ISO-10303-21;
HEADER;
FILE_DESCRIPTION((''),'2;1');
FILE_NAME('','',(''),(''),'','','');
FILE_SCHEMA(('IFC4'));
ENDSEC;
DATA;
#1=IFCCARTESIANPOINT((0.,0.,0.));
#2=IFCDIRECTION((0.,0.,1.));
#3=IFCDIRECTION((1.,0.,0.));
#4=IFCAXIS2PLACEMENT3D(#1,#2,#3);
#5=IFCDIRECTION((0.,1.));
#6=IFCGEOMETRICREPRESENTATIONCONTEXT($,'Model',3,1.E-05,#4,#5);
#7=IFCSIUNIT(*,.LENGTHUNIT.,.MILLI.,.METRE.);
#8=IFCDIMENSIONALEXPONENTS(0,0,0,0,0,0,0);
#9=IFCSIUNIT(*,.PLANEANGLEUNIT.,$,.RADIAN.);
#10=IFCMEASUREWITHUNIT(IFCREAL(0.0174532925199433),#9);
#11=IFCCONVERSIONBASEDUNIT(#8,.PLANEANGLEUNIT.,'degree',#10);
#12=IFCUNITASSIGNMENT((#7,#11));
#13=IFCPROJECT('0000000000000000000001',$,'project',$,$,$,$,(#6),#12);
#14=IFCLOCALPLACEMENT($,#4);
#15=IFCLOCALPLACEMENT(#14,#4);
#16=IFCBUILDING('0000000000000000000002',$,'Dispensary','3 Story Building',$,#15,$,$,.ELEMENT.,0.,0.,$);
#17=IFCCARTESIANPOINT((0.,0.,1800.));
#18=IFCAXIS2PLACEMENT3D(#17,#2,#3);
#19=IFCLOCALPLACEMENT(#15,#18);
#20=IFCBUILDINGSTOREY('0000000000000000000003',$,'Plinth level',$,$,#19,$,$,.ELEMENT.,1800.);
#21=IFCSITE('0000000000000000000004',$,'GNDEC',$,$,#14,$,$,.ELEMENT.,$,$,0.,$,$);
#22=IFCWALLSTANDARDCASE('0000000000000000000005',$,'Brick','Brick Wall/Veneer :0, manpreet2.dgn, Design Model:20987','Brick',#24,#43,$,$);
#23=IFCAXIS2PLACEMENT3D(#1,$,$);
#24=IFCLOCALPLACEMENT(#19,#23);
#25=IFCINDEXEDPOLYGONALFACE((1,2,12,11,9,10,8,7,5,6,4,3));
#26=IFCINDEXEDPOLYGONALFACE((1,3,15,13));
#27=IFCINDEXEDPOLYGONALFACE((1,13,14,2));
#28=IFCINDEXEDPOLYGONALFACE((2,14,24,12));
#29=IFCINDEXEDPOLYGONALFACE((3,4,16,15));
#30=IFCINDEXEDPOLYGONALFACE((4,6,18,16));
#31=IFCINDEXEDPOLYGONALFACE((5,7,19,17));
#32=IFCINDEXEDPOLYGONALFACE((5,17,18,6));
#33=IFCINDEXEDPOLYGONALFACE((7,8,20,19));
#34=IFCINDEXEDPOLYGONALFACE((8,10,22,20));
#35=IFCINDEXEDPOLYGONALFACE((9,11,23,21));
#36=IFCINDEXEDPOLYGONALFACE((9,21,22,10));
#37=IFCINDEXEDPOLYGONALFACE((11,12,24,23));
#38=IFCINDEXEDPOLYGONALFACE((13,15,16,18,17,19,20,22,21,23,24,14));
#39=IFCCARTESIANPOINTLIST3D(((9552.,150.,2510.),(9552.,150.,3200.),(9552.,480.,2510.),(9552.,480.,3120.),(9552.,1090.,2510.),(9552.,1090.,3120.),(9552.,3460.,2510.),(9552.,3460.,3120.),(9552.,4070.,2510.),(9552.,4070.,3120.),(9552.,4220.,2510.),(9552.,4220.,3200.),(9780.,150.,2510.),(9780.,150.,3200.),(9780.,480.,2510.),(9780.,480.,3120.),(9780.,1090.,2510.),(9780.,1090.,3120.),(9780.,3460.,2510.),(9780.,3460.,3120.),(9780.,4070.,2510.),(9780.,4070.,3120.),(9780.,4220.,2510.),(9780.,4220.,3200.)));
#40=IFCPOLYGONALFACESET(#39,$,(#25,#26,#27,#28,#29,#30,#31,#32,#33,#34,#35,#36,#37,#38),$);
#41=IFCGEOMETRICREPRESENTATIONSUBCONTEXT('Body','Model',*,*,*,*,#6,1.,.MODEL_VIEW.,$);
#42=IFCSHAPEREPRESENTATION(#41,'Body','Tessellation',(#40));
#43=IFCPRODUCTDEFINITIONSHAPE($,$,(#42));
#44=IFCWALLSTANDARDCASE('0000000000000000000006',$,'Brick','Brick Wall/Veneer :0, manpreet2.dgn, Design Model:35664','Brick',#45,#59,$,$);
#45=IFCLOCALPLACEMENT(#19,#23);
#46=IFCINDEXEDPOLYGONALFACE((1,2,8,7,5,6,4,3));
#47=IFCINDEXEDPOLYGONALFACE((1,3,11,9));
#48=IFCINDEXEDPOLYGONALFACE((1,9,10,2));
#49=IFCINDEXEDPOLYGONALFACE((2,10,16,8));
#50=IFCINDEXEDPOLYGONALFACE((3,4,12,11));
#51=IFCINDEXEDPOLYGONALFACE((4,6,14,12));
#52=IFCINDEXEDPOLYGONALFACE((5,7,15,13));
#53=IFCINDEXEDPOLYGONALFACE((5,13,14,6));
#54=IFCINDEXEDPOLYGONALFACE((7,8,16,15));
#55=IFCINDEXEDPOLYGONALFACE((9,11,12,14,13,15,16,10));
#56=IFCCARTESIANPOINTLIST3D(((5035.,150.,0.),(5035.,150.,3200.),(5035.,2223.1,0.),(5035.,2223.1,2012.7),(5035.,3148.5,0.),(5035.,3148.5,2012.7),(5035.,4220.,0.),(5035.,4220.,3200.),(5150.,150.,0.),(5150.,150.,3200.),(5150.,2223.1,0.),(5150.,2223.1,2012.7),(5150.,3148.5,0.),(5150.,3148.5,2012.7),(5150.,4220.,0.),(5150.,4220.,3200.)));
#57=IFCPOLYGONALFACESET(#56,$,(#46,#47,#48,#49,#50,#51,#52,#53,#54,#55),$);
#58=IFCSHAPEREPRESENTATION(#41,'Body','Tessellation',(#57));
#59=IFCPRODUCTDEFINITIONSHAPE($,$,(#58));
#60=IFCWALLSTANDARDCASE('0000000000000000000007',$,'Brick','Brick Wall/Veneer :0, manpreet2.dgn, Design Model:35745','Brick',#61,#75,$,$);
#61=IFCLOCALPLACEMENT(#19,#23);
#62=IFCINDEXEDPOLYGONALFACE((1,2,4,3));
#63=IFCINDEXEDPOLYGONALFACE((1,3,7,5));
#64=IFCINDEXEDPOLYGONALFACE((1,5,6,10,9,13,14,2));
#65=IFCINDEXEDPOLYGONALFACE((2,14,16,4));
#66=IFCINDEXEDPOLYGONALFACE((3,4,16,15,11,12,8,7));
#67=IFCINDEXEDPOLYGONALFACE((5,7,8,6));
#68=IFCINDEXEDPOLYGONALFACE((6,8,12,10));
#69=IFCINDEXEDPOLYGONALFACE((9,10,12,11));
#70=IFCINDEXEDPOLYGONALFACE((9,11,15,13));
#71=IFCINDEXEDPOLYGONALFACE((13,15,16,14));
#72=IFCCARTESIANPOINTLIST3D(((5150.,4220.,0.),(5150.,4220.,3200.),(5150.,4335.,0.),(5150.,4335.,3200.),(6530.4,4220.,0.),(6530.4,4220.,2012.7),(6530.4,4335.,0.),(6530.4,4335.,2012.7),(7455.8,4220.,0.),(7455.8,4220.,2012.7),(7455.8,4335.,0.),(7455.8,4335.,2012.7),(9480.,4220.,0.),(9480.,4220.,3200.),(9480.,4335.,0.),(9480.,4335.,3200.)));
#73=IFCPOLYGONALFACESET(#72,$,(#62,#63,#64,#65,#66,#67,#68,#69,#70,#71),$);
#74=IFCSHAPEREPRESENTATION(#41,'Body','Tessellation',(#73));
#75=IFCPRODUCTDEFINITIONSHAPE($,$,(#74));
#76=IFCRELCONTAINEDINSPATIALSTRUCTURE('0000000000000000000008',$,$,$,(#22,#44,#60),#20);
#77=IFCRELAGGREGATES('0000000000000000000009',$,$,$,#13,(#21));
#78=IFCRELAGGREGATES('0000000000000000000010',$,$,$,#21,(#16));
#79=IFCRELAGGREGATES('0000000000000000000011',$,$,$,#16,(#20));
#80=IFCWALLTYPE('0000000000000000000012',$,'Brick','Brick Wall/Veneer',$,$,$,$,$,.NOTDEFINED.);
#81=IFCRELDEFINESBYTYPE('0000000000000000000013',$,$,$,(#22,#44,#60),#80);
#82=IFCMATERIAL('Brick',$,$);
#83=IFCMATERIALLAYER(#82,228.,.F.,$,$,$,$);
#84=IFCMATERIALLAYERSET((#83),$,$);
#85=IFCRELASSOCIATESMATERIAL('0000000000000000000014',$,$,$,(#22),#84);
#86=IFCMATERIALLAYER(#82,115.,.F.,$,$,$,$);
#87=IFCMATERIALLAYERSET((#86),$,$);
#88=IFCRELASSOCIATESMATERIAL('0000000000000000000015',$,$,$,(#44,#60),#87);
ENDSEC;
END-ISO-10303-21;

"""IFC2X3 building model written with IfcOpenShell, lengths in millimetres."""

from ifc_helpers import new_model, entity, si_unit, converted_unit, direction, frame, frame_2d, origin_with_axes, place, context, subcontext, project, spatial, rectangle, extrude, material, layer, layer_set, layer_usage, type_object, element, save


model = new_model("IFC2X3")

# Units and contexts
model_context = context("Model", 3, precision=1e-05, world=origin_with_axes(), true_north=direction((0.0, 1.0)))
body_context = subcontext(model_context, "Body", "Model", "MODEL_VIEW", scale=1.0)
ifc_project = project(units=[si_unit("LENGTHUNIT", "METRE", prefix="MILLI"), converted_unit("PLANEANGLEUNIT", "degree", entity("IfcReal", 0.0174532925199433), si_unit("PLANEANGLEUNIT", "RADIAN"), dimensions=[0, 0, 0, 0, 0, 0, 0])], contexts=[model_context])

# Site, building, storey
site_placement = place(None, origin_with_axes())
site = spatial("IfcSite", under=ifc_project, at=site_placement, Name="GNDEC", CompositionType="ELEMENT", RefElevation=0.0)
building_placement = place(site_placement, origin_with_axes())
building = spatial("IfcBuilding", under=site, at=building_placement, Name="Dispensary", Description="3 Story Building", CompositionType="ELEMENT", ElevationOfRefHeight=0.0, ElevationOfTerrain=0.0)
storey_placement = place(building_placement, frame((0.0, 0.0, 1800.0), z_axis=(0.0, 0.0, 1.0), x_axis=(1.0, 0.0, 0.0)))
storey = spatial("IfcBuildingStorey", under=building, at=storey_placement, Name="Plinth level", CompositionType="ELEMENT", Elevation=1800.0)

# Wall, openings
ifc_material_1 = material(Name="Brick")
ifc_layer_1 = layer(ifc_material_1, 228.0, ventilated=False)
ifc_layer_set_1 = layer_set([ifc_layer_1])
ifc_layer_usage_1 = layer_usage(ifc_layer_set_1, "AXIS2", "POSITIVE", 0.0)
wall_type = type_object("IfcWallType", Name="Brick", Description="Brick Wall/Veneer", PredefinedType="NOTDEFINED")
wall_1_placement = place(storey_placement, frame((9780.0, 4220.0, 2510.0), z_axis=(0.0, 0.0, 1.0), x_axis=(0.0, -1.0, 0.0)))
wall_1 = element("IfcWallStandardCase", 1, at=wall_1_placement, inside=storey, type_object=wall_type, material=ifc_layer_usage_1, Name="Brick", Description="Brick Wall/Veneer :0, manpreet2.dgn, Design Model:20987", ObjectType="Brick", context=body_context, shape_type="SweptSolid", body=[
    extrude(rectangle(XDim=4070.0, YDim=228.0, at=frame_2d((2035.0, -114.0), x_axis=(-1.0, 0.0))), origin_with_axes(), (0.0, 0.0, 1.0), 690.0),
])
opening_1_placement = place(wall_1_placement, frame((150.0, -228.0, -760.0), z_axis=(0.0, 0.0, 1.0), x_axis=(1.0, 0.0, 0.0)))
element("IfcOpeningElement", 2, at=opening_1_placement, cuts=wall_1, ObjectType="Opening", context=body_context, shape_type="SweptSolid", body=[
    extrude(rectangle(XDim=1370.0, YDim=610.0, at=frame_2d((-305.0, 685.0), x_axis=(0.0, -1.0))), frame((0.0, 0.0, 0.0), z_axis=(0.0, 1.0, 0.0), x_axis=(-1.0, 0.0, 0.0)), (0.0, 0.0, 1.0), 228.0),
])
opening_2_placement = place(wall_1_placement, frame((3130.0, -228.0, -760.0), z_axis=(0.0, 0.0, 1.0), x_axis=(1.0, 0.0, 0.0)))
element("IfcOpeningElement", 3, at=opening_2_placement, cuts=wall_1, ObjectType="Opening", context=body_context, shape_type="SweptSolid", body=[
    extrude(rectangle(XDim=1370.0, YDim=610.0, at=frame_2d((-305.0, 685.0), x_axis=(0.0, -1.0))), frame((0.0, 0.0, 0.0), z_axis=(0.0, 1.0, 0.0), x_axis=(-1.0, 0.0, 0.0)), (0.0, 0.0, 1.0), 228.0),
])

# Walls, openings
ifc_layer_2 = layer(ifc_material_1, 115.0, ventilated=False)
ifc_layer_set_2 = layer_set([ifc_layer_2])
ifc_layer_usage_2 = layer_usage(ifc_layer_set_2, "AXIS2", "POSITIVE", 0.0)
wall_2_placement = place(storey_placement, frame((5150.0, 4220.0, 0.0), z_axis=(0.0, 0.0, 1.0), x_axis=(0.0, -1.0, 0.0)))
wall_2 = element("IfcWallStandardCase", 4, at=wall_2_placement, inside=storey, type_object=wall_type, material=ifc_layer_usage_2, Name="Brick", Description="Brick Wall/Veneer :0, manpreet2.dgn, Design Model:35664", ObjectType="Brick", context=body_context, shape_type="SweptSolid", body=[
    extrude(rectangle(XDim=4070.0, YDim=115.0, at=frame_2d((2035.0, -57.5), x_axis=(-1.0, 0.0))), origin_with_axes(), (0.0, 0.0, 1.0), 3200.0),
])
opening_3_placement = place(wall_2_placement, frame((1071.5, -115.0, 0.0), z_axis=(0.0, 0.0, 1.0), x_axis=(1.0, 0.0, 0.0)))
element("IfcOpeningElement", 5, at=opening_3_placement, cuts=wall_2, ObjectType="Opening", context=body_context, shape_type="SweptSolid", body=[
    extrude(rectangle(XDim=2012.7, YDim=925.4, at=frame_2d((-462.7, 1006.4), x_axis=(0.0, -1.0))), frame((0.0, 0.0, 0.0), z_axis=(0.0, 1.0, 0.0), x_axis=(-1.0, 0.0, 0.0)), (0.0, 0.0, 1.0), 115.0),
])
wall_3_placement = place(storey_placement, frame((9480.0, 4220.0, 0.0), z_axis=(0.0, 0.0, 1.0), x_axis=(-1.0, 0.0, 0.0)))
wall_3 = element("IfcWallStandardCase", 6, at=wall_3_placement, inside=storey, type_object=wall_type, material=ifc_layer_usage_2, Name="Brick", Description="Brick Wall/Veneer :0, manpreet2.dgn, Design Model:35745", ObjectType="Brick", context=body_context, shape_type="SweptSolid", body=[
    extrude(rectangle(XDim=4330.0, YDim=115.0, at=frame_2d((2165.0, -57.5), x_axis=(-1.0, 0.0))), origin_with_axes(), (0.0, 0.0, 1.0), 3200.0),
])
opening_4_placement = place(wall_3_placement, frame((2024.2, -115.0, 0.0), z_axis=(0.0, 0.0, 1.0), x_axis=(1.0, 0.0, 0.0)))
element("IfcOpeningElement", 7, at=opening_4_placement, cuts=wall_3, ObjectType="Opening", context=body_context, shape_type="SweptSolid", body=[
    extrude(rectangle(XDim=2012.7, YDim=925.4, at=frame_2d((-462.7, 1006.4), x_axis=(0.0, -1.0))), frame((0.0, 0.0, 0.0), z_axis=(0.0, 1.0, 0.0), x_axis=(-1.0, 0.0, 0.0)), (0.0, 0.0, 1.0), 115.0),
])

save(model, "model.ifc")
